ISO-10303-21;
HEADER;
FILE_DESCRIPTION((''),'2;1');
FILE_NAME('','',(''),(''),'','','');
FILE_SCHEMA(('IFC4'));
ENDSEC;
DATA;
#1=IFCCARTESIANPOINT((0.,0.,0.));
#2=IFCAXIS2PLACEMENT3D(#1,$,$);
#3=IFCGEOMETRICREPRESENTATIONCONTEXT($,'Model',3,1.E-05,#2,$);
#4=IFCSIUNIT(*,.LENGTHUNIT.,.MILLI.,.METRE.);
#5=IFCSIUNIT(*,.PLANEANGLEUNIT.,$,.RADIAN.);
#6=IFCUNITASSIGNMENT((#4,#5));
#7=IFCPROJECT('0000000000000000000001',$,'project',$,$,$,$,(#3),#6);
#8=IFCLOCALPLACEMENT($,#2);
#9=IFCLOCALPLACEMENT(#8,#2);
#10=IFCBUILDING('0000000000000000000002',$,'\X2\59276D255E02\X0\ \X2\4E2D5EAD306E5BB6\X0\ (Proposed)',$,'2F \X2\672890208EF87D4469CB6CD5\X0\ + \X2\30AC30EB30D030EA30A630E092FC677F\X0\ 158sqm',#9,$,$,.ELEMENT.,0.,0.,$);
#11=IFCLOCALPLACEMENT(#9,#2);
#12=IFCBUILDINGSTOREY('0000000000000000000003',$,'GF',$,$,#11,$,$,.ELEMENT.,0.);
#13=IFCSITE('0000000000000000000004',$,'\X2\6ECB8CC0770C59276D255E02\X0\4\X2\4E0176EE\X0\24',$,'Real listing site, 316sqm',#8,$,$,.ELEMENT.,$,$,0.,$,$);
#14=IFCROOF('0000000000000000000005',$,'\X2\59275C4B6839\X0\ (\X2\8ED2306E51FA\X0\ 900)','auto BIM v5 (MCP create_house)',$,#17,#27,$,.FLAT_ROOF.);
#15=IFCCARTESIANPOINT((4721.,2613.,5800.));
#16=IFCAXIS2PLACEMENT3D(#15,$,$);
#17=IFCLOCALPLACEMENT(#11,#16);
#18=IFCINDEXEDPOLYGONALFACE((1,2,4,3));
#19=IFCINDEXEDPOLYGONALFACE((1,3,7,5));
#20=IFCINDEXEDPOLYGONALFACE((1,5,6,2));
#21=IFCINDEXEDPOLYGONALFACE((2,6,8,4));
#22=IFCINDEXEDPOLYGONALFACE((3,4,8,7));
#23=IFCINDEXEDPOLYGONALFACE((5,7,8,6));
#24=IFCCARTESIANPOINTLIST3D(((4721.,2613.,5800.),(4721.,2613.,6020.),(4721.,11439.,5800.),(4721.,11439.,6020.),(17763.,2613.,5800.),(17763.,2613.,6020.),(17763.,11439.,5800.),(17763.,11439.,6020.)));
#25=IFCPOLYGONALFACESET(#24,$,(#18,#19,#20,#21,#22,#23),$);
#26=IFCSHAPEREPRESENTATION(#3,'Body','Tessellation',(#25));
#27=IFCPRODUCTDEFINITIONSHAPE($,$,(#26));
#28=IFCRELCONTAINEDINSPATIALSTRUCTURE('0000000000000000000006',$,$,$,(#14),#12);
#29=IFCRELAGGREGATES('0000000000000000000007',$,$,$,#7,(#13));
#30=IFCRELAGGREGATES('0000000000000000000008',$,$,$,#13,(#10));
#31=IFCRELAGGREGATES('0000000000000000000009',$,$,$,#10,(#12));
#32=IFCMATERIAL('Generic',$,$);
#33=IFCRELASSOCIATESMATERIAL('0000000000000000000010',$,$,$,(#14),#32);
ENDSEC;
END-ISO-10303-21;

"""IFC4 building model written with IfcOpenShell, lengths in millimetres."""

from ifc_helpers import new_model, si_unit, frame, frame_2d, origin, place, context, project, spatial, rectangle, extrude, material, element, save


model = new_model("IFC4")

# Units and contexts
model_context = context("Model", 3, precision=1e-05, world=origin())
ifc_project = project(units=[si_unit("LENGTHUNIT", "METRE", prefix="MILLI"), si_unit("PLANEANGLEUNIT", "RADIAN")], contexts=[model_context])

# Site, building, storey
site_placement = place(None, origin())
site = spatial("IfcSite", under=ifc_project, at=site_placement, Name="滋賀県大津市4丁目24", ObjectType="Real listing site, 316sqm", CompositionType="ELEMENT", RefElevation=0.0)
building_placement = place(site_placement, origin())
building = spatial("IfcBuilding", under=site, at=building_placement, Name="大津市 中庭の家 (Proposed)", ObjectType="2F 木造軸組構法 + ガルバリウム鋼板 158sqm", CompositionType="ELEMENT", ElevationOfRefHeight=0.0, ElevationOfTerrain=0.0)
storey_placement = place(building_placement, origin())
storey = spatial("IfcBuildingStorey", under=building, at=storey_placement, Name="GF", CompositionType="ELEMENT", Elevation=0.0)

# Shared definitions
ifc_material = material(Name="Generic")

# Roof
roof_placement = place(storey_placement, frame((4721.0, 2613.0, 5800.0)))
element("IfcRoof", 1, at=roof_placement, inside=storey, material=ifc_material, Name="大屋根 (軒の出 900)", Description="auto BIM v5 (MCP create_house)", PredefinedType="FLAT_ROOF", context=model_context, shape_type="SweptSolid", body=[
    extrude(rectangle(XDim=13042.0, YDim=8826.0, at=frame_2d((6521.0, 4413.0))), frame((4721.0, 2613.0, 5800.0)), (0.0, 0.0, 1.0), 220.0),
])

save(model, "model.ifc")
